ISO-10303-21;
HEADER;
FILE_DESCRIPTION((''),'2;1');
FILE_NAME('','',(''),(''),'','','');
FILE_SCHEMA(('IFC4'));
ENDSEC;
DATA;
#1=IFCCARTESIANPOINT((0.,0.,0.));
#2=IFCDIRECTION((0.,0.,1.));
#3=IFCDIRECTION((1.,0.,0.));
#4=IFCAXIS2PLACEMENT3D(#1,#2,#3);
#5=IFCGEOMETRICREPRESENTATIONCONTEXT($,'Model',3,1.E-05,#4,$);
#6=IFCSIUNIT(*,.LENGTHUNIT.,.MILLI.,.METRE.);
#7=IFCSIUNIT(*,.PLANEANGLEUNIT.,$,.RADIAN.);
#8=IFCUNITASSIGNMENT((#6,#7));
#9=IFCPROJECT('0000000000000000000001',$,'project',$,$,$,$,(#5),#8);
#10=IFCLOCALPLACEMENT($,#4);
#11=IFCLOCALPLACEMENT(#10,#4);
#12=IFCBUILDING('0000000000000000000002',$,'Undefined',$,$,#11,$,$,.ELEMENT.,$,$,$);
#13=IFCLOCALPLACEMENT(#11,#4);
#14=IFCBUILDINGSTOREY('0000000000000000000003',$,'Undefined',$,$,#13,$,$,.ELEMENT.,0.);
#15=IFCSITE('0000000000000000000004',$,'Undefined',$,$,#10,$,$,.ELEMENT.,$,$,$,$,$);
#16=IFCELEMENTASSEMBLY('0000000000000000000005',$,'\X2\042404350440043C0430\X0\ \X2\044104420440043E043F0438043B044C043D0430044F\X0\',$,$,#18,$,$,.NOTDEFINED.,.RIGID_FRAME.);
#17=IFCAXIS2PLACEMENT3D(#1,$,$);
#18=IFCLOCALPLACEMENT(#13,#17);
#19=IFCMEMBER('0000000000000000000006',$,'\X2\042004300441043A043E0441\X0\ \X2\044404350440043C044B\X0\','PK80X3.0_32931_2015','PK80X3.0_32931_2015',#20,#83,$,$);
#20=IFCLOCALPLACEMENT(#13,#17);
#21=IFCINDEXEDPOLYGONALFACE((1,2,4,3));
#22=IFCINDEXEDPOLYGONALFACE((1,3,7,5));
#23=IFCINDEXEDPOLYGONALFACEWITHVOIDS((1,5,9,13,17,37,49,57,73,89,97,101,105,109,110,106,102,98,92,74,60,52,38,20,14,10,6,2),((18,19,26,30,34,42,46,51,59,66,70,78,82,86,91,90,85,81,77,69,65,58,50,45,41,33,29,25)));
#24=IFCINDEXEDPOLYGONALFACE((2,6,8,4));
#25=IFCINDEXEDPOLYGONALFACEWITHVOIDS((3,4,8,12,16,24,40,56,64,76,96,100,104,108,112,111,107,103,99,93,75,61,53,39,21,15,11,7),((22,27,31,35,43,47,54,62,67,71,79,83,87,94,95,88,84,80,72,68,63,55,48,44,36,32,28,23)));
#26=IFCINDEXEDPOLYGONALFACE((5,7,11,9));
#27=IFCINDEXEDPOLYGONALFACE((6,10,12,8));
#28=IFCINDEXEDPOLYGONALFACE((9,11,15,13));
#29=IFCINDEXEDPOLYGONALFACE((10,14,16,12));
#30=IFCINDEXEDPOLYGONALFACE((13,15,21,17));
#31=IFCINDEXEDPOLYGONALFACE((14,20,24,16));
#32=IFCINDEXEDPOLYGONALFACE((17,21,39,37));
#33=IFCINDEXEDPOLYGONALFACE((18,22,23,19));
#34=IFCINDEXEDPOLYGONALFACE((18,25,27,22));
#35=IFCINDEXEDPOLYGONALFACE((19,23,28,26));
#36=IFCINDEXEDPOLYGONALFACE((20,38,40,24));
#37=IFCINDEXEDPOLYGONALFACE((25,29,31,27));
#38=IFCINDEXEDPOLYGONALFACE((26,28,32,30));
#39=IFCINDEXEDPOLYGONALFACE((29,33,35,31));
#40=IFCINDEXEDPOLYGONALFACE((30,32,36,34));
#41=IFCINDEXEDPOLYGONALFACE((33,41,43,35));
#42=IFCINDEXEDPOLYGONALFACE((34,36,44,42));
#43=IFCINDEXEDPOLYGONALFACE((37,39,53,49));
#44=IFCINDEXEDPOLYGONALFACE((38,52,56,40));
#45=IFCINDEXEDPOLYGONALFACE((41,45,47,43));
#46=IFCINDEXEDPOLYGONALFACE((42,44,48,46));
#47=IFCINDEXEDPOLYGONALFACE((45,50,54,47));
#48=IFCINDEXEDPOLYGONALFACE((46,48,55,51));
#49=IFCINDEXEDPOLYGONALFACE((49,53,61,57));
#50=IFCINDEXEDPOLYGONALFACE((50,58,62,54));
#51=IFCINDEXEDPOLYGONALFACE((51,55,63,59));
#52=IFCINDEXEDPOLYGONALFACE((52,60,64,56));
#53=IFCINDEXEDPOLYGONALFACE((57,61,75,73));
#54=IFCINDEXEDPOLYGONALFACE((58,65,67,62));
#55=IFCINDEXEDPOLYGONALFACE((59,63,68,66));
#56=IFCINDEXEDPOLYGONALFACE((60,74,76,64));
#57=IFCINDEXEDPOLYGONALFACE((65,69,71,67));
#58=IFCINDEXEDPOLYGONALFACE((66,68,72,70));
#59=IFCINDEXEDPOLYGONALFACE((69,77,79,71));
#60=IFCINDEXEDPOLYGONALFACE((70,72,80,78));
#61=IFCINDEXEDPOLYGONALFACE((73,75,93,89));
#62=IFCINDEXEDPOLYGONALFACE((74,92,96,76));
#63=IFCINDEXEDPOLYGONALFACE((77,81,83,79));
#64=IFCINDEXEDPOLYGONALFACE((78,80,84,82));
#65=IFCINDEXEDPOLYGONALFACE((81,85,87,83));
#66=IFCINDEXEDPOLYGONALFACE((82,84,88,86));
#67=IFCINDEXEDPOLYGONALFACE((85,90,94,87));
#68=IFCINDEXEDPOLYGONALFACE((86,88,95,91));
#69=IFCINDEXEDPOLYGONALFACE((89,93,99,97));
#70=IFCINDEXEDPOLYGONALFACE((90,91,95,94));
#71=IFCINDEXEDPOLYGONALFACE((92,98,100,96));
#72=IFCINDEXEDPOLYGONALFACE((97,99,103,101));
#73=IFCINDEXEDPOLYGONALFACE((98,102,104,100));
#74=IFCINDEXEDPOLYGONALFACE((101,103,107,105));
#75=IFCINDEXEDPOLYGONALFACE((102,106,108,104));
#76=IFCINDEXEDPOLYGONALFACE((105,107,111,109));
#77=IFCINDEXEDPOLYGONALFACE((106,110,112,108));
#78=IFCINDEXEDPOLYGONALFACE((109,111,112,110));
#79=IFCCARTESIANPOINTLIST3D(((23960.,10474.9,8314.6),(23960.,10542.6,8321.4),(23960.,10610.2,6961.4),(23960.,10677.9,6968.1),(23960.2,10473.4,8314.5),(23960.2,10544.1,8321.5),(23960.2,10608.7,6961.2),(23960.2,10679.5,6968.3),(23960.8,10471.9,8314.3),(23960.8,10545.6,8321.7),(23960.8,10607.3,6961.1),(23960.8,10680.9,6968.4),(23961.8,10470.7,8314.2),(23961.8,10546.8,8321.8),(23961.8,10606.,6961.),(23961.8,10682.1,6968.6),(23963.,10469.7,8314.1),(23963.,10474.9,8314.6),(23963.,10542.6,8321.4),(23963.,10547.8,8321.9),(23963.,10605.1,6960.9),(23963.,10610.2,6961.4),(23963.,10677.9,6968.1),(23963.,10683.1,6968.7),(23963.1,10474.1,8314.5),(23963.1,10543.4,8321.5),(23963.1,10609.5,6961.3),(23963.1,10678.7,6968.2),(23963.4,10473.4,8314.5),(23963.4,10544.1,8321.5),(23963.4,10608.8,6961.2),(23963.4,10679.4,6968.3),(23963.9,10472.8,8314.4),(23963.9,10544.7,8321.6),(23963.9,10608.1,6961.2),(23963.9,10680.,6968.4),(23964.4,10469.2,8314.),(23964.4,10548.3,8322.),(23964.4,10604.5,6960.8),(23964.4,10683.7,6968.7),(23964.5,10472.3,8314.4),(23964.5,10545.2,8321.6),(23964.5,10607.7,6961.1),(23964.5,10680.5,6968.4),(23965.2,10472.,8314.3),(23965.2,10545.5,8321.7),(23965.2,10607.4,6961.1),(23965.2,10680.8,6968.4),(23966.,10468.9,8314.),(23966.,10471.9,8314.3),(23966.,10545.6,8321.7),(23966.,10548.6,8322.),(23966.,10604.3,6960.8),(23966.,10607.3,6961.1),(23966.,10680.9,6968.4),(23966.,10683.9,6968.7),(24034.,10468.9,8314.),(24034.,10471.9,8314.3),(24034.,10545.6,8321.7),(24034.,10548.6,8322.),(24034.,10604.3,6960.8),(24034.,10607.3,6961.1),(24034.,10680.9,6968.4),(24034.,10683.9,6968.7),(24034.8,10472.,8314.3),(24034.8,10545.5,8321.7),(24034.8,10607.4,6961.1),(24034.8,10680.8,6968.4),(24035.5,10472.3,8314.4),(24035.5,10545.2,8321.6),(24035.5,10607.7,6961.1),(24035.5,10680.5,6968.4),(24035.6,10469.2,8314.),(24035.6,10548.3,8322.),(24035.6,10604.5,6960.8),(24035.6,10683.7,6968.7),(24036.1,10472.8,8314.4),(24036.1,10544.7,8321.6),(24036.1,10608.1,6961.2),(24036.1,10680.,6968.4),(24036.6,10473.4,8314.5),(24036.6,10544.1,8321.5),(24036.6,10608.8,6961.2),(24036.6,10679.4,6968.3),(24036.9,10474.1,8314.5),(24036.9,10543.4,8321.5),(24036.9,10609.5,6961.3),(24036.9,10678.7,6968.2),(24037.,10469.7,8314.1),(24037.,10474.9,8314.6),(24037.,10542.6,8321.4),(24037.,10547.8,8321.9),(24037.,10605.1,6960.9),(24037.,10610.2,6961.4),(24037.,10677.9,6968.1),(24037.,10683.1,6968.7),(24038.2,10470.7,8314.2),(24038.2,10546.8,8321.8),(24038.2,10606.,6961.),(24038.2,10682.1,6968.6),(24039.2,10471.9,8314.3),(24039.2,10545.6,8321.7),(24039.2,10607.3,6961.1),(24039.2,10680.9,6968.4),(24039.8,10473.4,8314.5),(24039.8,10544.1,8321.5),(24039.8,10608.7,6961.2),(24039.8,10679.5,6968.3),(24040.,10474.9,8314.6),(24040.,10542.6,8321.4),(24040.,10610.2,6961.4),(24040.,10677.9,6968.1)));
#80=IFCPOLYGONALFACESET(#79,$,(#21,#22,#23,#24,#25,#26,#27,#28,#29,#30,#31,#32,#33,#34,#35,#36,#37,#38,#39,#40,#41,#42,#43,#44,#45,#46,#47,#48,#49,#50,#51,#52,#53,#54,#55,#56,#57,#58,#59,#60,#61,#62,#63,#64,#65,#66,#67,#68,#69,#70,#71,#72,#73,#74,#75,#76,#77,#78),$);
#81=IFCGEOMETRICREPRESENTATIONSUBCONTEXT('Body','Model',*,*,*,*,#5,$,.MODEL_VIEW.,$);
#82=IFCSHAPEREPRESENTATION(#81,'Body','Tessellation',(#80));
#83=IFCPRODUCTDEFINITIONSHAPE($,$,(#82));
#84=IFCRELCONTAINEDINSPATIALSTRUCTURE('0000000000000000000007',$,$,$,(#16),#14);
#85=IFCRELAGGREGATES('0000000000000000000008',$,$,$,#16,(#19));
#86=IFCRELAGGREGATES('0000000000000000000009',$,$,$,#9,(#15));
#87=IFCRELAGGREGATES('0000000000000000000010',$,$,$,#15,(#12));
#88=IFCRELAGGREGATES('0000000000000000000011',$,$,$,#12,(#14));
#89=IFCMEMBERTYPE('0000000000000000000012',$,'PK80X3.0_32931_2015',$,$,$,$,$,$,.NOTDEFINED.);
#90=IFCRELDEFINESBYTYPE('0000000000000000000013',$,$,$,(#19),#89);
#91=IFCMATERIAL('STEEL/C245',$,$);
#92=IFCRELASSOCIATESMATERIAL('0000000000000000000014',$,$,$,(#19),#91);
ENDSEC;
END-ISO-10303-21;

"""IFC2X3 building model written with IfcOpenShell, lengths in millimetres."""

from ifc_helpers import new_model, si_unit, frame, origin_with_axes, origin_2d_with_axis, place, context, subcontext, project, spatial, hollow_rectangle, extrude, material, type_object, element, aggregate, save


model = new_model("IFC2X3")

# Units and contexts
model_context = context("Model", 3, precision=1e-05, world=origin_with_axes())
body_context = subcontext(model_context, "Body", "Model", "MODEL_VIEW")
ifc_project = project(units=[si_unit("LENGTHUNIT", "METRE", prefix="MILLI"), si_unit("PLANEANGLEUNIT", "RADIAN")], contexts=[model_context])

# Site, building, storey
site_placement = place(None, origin_with_axes())
site = spatial("IfcSite", under=ifc_project, at=site_placement, Name="Undefined", CompositionType="ELEMENT")
building_placement = place(site_placement, origin_with_axes())
building = spatial("IfcBuilding", under=site, at=building_placement, Name="Undefined", CompositionType="ELEMENT")
storey_placement = place(building_placement, origin_with_axes())
storey = spatial("IfcBuildingStorey", under=building, at=storey_placement, Name="Undefined", CompositionType="ELEMENT", Elevation=0.0)

# Shared definitions
ifc_material_1 = material(Name="STEEL/C245")

# Element assembly, member
assembly_1_placement = place(storey_placement, origin_with_axes())
assembly_1 = element("IfcElementAssembly", 1, at=assembly_1_placement, inside=storey, Name="Ферма стропильная", AssemblyPlace="NOTDEFINED", PredefinedType="RIGID_FRAME")
member_type_1 = type_object("IfcMemberType", Name="PK80X3.0_32931_2015", PredefinedType="NOTDEFINED")
member_1_placement = place(assembly_1_placement, frame((24000.0, 10508.8, 8318.0), z_axis=(0.0, 0.995037, 0.099504), x_axis=(0.0, 0.099504, -0.995037)))
member_1 = element("IfcMember", 2, at=member_1_placement, type_object=member_type_1, material=ifc_material_1, Name="Раскос фермы", Description="PK80X3.0_32931_2015", ObjectType="PK80X3.0_32931_2015", context=body_context, shape_type="SweptSolid", body=[
    extrude(hollow_rectangle(XDim=80.0, YDim=80.0, WallThickness=3.0, InnerFilletRadius=3.0, OuterFilletRadius=6.0, at=origin_2d_with_axis()), frame((1360.0, 0.0, 0.0), z_axis=(-1.0, 0.0, 0.0), x_axis=(0.0, -1.0, 0.0)), (0.0, 0.0, 1.0), 1360.0),
])
aggregate(assembly_1, [member_1])

save(model, "model.ifc")
